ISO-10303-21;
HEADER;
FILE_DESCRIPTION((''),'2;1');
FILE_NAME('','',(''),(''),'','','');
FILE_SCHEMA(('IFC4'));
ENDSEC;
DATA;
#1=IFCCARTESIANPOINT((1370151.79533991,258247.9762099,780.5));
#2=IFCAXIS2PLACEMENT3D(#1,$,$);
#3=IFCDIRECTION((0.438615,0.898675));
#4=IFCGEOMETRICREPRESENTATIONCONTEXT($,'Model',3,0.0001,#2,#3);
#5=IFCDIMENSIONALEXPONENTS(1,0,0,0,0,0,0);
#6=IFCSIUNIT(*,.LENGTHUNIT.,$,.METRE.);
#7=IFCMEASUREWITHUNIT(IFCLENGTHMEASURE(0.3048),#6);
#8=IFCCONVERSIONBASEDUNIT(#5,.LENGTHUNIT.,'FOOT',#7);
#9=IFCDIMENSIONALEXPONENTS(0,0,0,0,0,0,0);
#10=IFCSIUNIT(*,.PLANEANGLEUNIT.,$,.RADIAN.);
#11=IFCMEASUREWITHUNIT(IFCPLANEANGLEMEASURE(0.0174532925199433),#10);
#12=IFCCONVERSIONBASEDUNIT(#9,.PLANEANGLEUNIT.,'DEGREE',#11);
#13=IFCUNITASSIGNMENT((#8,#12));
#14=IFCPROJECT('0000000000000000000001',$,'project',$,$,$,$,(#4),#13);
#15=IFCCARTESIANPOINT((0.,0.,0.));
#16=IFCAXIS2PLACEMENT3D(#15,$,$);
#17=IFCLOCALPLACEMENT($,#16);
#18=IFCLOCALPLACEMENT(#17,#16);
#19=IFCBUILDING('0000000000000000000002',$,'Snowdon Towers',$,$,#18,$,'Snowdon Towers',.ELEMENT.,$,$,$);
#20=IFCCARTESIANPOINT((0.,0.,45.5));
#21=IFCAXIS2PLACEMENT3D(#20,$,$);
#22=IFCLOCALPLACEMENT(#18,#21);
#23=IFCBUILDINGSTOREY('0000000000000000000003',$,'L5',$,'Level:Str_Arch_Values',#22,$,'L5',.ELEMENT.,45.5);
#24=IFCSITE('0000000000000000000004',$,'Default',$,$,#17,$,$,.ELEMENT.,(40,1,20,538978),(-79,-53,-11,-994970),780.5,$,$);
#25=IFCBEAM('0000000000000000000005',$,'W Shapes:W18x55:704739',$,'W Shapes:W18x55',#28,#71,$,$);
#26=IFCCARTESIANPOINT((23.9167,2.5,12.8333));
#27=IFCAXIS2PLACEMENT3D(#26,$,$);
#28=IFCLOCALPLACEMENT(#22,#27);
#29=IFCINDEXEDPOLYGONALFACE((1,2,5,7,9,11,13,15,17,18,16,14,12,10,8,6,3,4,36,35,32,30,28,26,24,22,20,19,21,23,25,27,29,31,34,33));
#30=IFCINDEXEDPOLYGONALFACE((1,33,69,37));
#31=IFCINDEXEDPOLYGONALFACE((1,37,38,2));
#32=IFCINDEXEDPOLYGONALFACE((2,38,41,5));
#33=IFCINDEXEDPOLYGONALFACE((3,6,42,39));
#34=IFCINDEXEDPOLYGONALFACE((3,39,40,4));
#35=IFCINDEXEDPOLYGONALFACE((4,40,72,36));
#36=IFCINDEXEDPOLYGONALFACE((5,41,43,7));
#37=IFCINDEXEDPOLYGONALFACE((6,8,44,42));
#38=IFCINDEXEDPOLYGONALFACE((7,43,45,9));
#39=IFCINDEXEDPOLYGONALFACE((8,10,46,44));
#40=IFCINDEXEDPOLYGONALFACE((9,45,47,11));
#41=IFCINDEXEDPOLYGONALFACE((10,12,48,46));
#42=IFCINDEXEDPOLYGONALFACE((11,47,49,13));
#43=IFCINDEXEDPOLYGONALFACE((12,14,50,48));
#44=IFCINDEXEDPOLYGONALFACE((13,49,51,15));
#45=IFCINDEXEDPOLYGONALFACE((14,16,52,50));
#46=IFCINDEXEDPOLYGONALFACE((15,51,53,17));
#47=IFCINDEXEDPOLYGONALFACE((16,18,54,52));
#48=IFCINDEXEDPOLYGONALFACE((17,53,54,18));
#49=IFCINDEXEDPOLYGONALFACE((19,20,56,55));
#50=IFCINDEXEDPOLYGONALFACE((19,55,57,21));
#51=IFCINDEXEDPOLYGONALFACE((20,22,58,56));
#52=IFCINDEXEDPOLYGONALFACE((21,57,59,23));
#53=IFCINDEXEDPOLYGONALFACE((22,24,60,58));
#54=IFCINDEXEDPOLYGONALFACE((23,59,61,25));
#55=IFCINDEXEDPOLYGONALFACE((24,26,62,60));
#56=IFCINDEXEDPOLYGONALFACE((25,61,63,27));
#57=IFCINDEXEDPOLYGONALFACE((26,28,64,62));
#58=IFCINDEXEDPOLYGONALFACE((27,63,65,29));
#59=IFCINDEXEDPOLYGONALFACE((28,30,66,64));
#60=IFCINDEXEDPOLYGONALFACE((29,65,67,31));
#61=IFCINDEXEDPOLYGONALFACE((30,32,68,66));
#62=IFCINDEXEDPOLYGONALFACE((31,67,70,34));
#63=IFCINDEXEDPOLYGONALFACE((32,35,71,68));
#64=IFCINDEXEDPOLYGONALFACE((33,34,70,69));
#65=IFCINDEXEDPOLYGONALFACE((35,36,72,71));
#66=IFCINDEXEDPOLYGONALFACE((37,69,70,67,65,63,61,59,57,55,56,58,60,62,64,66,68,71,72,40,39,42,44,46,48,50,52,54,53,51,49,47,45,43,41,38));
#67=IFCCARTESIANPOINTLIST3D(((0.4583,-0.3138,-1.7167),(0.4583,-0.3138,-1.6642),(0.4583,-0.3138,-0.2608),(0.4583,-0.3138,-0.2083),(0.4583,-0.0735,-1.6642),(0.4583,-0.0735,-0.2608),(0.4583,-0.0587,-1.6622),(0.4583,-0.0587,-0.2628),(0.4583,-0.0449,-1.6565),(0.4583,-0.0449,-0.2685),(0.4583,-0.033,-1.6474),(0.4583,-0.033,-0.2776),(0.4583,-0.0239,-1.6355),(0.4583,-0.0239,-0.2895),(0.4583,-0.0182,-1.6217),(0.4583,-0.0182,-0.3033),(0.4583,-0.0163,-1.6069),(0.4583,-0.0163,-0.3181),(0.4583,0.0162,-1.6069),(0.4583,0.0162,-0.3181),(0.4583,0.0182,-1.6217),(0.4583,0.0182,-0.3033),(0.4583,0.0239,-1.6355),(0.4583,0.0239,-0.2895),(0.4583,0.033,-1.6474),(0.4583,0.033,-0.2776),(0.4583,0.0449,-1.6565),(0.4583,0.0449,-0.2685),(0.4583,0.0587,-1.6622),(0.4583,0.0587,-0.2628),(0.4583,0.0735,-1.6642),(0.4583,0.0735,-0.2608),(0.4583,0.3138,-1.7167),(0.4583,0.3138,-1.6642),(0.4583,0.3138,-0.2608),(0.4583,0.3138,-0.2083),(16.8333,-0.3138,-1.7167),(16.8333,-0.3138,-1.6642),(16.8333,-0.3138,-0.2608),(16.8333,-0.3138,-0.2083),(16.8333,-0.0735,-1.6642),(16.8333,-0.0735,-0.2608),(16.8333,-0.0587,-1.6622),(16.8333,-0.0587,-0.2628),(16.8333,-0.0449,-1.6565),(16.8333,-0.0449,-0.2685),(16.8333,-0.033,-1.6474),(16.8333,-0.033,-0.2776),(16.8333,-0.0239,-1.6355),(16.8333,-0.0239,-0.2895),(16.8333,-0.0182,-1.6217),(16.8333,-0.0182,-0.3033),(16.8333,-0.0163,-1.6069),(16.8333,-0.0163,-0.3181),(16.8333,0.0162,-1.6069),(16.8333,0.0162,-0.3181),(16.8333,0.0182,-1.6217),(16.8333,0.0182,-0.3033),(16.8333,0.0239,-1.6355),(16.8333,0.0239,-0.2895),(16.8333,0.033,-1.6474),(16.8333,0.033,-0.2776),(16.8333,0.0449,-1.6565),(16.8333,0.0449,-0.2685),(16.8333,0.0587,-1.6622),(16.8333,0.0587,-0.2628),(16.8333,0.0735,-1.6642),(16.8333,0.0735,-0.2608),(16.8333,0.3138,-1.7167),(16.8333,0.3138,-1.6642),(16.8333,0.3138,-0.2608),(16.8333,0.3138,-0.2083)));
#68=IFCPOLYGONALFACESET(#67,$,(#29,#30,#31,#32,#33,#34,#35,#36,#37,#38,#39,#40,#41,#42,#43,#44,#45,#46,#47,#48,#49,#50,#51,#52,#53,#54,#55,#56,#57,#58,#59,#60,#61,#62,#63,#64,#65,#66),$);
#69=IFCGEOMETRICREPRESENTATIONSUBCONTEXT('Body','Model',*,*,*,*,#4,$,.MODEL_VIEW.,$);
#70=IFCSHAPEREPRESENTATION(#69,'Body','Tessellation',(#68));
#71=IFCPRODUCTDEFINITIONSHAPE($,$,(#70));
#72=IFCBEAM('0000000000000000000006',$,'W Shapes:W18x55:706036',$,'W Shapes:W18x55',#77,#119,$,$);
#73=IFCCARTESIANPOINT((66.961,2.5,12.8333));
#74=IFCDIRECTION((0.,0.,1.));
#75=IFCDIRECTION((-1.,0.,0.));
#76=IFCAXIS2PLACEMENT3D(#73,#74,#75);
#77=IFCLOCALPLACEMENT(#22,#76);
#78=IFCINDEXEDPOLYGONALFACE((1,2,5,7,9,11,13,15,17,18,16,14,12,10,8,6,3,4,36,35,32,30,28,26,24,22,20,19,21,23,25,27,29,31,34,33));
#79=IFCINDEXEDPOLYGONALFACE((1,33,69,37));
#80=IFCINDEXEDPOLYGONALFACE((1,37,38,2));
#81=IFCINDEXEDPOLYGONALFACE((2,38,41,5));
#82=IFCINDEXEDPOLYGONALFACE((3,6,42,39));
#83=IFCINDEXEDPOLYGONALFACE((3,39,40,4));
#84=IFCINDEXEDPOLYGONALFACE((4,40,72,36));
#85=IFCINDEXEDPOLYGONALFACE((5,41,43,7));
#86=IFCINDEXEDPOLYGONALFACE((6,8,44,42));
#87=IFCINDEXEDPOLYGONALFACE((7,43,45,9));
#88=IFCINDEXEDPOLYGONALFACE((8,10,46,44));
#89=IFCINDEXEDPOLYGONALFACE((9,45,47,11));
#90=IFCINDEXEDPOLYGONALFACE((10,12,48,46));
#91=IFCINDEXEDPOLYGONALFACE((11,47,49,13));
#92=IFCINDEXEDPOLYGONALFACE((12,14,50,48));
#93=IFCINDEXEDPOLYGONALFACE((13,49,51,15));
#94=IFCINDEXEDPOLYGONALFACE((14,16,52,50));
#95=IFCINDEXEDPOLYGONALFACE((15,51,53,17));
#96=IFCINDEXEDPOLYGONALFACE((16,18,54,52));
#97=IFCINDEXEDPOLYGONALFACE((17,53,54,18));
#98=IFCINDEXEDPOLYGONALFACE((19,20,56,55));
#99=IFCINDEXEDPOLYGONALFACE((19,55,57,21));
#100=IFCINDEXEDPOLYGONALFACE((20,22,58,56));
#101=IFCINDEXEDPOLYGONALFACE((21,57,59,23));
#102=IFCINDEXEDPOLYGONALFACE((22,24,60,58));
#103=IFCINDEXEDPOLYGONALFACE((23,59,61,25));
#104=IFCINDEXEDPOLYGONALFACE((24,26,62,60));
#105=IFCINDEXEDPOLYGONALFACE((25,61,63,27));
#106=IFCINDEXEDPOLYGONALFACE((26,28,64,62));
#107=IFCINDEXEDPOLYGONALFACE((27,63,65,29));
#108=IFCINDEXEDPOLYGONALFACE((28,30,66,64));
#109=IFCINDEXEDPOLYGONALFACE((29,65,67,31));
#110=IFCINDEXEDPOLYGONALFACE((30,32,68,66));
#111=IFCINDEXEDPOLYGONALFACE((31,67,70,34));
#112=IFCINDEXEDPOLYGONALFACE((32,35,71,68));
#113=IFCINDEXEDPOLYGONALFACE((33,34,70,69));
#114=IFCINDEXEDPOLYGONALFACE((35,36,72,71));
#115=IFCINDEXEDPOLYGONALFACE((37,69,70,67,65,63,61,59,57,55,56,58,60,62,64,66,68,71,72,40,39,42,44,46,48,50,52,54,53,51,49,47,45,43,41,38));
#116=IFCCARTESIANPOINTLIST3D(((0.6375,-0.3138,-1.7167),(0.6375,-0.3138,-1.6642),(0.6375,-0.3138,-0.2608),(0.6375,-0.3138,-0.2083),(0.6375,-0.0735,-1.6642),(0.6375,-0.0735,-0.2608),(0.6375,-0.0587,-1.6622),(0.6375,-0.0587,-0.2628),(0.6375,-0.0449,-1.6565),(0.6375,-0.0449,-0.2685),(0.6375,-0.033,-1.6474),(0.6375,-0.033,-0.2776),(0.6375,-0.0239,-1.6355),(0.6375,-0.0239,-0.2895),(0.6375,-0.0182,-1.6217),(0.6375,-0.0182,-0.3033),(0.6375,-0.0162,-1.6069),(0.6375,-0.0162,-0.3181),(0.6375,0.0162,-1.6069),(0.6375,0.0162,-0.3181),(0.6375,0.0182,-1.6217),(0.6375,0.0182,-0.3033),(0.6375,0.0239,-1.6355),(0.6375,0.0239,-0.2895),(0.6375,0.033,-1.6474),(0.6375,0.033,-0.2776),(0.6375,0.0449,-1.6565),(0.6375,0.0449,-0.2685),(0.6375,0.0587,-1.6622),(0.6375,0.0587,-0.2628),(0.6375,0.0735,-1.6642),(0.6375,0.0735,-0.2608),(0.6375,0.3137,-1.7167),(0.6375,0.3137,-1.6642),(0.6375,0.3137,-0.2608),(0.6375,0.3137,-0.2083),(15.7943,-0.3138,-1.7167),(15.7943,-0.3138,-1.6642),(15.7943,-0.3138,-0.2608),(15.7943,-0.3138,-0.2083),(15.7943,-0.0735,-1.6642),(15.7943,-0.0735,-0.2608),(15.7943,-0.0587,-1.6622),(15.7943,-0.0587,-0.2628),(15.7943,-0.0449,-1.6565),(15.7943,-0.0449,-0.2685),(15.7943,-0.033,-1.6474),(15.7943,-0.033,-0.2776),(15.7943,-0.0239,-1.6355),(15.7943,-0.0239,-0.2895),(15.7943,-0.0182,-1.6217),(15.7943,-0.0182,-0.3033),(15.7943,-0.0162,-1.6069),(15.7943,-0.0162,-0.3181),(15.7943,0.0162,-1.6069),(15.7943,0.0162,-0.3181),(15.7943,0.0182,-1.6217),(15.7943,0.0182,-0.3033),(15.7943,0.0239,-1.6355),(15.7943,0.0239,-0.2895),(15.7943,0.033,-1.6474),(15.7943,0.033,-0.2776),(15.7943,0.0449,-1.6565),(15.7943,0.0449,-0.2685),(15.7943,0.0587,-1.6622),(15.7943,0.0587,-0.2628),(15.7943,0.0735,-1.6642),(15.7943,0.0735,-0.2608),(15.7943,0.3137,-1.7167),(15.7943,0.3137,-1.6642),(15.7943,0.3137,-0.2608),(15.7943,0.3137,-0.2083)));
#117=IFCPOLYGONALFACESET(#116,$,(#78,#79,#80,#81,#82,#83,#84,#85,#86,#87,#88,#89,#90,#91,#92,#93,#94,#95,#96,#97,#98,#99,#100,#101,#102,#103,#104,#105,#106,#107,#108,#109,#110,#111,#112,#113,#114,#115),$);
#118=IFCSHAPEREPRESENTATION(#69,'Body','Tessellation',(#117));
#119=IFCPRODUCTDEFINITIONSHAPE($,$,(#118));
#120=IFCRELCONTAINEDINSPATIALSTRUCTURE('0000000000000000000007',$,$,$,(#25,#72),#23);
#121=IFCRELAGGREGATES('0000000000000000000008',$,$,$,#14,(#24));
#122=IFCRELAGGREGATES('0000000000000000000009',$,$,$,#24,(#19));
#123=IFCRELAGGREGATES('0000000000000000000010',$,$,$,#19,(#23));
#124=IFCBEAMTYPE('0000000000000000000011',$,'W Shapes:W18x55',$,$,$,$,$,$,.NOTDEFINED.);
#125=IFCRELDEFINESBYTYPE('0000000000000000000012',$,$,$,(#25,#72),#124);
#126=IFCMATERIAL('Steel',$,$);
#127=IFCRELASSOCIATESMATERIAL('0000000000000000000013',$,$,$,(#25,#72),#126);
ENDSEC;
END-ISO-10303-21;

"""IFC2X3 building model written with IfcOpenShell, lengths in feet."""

from ifc_helpers import new_model, entity, si_unit, converted_unit, direction, frame, frame_2d, origin, place, context, subcontext, project, spatial, i_section, extrude, material, type_object, element, save


model = new_model("IFC2X3")

# Units and contexts
model_context = context("Model", 3, precision=0.0001, world=frame((1370151.79533991, 258247.9762099, 780.5)), true_north=direction((0.438615, 0.898675)))
body_context = subcontext(model_context, "Body", "Model", "MODEL_VIEW")
ifc_project = project(units=[converted_unit("LENGTHUNIT", "FOOT", entity("IfcLengthMeasure", 0.3048), si_unit("LENGTHUNIT", "METRE"), dimensions=[1, 0, 0, 0, 0, 0, 0]), converted_unit("PLANEANGLEUNIT", "DEGREE", entity("IfcPlaneAngleMeasure", 0.0174532925199433), si_unit("PLANEANGLEUNIT", "RADIAN"), dimensions=[0, 0, 0, 0, 0, 0, 0])], contexts=[model_context])

# Site, building, storey
site_placement = place(None, origin())
site = spatial("IfcSite", under=ifc_project, at=site_placement, Name="Default", CompositionType="ELEMENT", RefLatitude=(40, 1, 20, 538978), RefLongitude=(-79, -53, -11, -994970), RefElevation=780.5)
building_placement = place(site_placement, origin())
building = spatial("IfcBuilding", under=site, at=building_placement, Name="Snowdon Towers", LongName="Snowdon Towers", CompositionType="ELEMENT")
storey_placement = place(building_placement, frame((0.0, 0.0, 45.5)))
storey = spatial("IfcBuildingStorey", under=building, at=storey_placement, Name="L5", ObjectType="Level:Str_Arch_Values", LongName="L5", CompositionType="ELEMENT", Elevation=45.5)

# Shared definitions
ifc_material = material(Name="Steel")

# Beams
beam_type_1 = type_object("IfcBeamType", Name="W Shapes:W18x55", PredefinedType="NOTDEFINED")
beam_1_placement = place(storey_placement, frame((23.9167, 2.5, 12.8333)))
element("IfcBeam", 1, at=beam_1_placement, inside=storey, type_object=beam_type_1, material=ifc_material, Name="W Shapes:W18x55:704739", ObjectType="W Shapes:W18x55", context=body_context, shape_type="SweptSolid", body=[
    extrude(i_section(OverallWidth=0.6275, OverallDepth=1.5083, WebThickness=0.0325, FlangeThickness=0.0525, FilletRadius=0.0573, at=frame_2d((0.0, 0.0), x_axis=(0.0, 1.0))), frame((0.4583, 0.0, -0.9625), z_axis=(1.0, 0.0, 0.0), x_axis=(0.0, 0.0, -1.0)), (0.0, 0.0, 1.0), 16.375),
])
beam_2_placement = place(storey_placement, frame((66.961, 2.5, 12.8333), z_axis=(0.0, 0.0, 1.0), x_axis=(-1.0, 0.0, 0.0)))
element("IfcBeam", 2, at=beam_2_placement, inside=storey, type_object=beam_type_1, material=ifc_material, Name="W Shapes:W18x55:706036", ObjectType="W Shapes:W18x55", context=body_context, shape_type="SweptSolid", body=[
    extrude(i_section(OverallWidth=0.6275, OverallDepth=1.5083, WebThickness=0.0325, FlangeThickness=0.0525, FilletRadius=0.0573, at=frame_2d((0.0, 0.0), x_axis=(0.0, 1.0))), frame((0.6375, 0.0, -0.9625), z_axis=(1.0, 0.0, 0.0), x_axis=(0.0, 0.0, -1.0)), (0.0, 0.0, 1.0), 15.1568),
])

save(model, "model.ifc")
